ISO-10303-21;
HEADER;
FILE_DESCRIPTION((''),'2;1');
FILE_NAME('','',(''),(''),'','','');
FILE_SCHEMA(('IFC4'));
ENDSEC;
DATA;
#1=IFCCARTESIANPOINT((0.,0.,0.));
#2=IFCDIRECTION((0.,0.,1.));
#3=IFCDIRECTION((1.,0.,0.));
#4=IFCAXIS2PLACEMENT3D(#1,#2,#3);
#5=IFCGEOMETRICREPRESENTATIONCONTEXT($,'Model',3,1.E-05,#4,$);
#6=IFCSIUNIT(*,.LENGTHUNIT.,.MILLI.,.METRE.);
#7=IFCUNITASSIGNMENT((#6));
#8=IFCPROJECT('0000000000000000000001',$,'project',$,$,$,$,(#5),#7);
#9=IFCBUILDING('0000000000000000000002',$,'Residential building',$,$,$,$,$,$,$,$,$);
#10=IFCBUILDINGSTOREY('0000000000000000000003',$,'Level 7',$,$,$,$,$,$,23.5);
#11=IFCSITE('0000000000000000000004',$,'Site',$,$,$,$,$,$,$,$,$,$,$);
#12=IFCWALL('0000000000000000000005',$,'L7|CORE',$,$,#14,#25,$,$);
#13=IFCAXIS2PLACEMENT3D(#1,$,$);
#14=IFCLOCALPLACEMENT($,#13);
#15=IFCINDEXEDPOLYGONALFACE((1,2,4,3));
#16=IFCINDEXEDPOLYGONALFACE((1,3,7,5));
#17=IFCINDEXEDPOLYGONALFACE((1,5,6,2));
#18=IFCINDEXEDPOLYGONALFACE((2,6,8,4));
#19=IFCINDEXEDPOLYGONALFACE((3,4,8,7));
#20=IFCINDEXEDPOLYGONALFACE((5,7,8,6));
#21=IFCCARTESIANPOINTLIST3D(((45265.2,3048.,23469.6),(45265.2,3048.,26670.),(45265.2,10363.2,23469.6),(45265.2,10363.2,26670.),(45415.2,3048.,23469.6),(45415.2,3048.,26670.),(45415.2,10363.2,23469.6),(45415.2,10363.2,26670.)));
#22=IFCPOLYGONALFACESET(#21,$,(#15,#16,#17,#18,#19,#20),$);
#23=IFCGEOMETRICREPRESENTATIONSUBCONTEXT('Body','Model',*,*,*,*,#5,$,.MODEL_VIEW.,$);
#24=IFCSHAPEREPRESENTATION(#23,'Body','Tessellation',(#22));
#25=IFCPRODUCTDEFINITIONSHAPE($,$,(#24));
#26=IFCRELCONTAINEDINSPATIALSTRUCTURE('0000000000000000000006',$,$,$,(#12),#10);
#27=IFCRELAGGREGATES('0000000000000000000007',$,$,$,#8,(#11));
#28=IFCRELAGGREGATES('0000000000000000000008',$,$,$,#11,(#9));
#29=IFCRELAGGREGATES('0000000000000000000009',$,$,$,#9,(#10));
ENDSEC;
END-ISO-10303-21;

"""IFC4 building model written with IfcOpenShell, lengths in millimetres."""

from ifc_helpers import new_model, si_unit, frame, origin_with_axes, place, context, subcontext, project, spatial, indexed_curve, outline, extrude, element, save


model = new_model("IFC4")

# Units and contexts
model_context = context("Model", 3, precision=1e-05, world=origin_with_axes())
body_context = subcontext(model_context, "Body", "Model", "MODEL_VIEW")
ifc_project = project(units=[si_unit("LENGTHUNIT", "METRE", prefix="MILLI")], contexts=[model_context])

# Site, building, storey
site = spatial("IfcSite", under=ifc_project, Name="Site")
building = spatial("IfcBuilding", under=site, Name="Residential building")
storey = spatial("IfcBuildingStorey", under=building, Name="Level 7", Elevation=23.5)

# Wall
for number, where, z_axis, x_axis, name in (
    (1, (45415.2, 3048.0, 23469.6), (0.0, 0.0, 1.0), (0.0, 1.0, 0.0), "L7|CORE"),
):
    element("IfcWall", number, at=place(None, frame(where, z_axis=z_axis, x_axis=x_axis)), inside=storey, Name=name, context=body_context, shape_type="SweptSolid", body=[
        extrude(outline(indexed_curve([(0.0, 0.0), (0.0, 150.0), (7315.2, 150.0), (7315.2, 0.0), (0.0, 0.0)], self_intersect=False)), origin_with_axes(), (0.0, 0.0, 1.0), 3200.4),
    ])

save(model, "model.ifc")
